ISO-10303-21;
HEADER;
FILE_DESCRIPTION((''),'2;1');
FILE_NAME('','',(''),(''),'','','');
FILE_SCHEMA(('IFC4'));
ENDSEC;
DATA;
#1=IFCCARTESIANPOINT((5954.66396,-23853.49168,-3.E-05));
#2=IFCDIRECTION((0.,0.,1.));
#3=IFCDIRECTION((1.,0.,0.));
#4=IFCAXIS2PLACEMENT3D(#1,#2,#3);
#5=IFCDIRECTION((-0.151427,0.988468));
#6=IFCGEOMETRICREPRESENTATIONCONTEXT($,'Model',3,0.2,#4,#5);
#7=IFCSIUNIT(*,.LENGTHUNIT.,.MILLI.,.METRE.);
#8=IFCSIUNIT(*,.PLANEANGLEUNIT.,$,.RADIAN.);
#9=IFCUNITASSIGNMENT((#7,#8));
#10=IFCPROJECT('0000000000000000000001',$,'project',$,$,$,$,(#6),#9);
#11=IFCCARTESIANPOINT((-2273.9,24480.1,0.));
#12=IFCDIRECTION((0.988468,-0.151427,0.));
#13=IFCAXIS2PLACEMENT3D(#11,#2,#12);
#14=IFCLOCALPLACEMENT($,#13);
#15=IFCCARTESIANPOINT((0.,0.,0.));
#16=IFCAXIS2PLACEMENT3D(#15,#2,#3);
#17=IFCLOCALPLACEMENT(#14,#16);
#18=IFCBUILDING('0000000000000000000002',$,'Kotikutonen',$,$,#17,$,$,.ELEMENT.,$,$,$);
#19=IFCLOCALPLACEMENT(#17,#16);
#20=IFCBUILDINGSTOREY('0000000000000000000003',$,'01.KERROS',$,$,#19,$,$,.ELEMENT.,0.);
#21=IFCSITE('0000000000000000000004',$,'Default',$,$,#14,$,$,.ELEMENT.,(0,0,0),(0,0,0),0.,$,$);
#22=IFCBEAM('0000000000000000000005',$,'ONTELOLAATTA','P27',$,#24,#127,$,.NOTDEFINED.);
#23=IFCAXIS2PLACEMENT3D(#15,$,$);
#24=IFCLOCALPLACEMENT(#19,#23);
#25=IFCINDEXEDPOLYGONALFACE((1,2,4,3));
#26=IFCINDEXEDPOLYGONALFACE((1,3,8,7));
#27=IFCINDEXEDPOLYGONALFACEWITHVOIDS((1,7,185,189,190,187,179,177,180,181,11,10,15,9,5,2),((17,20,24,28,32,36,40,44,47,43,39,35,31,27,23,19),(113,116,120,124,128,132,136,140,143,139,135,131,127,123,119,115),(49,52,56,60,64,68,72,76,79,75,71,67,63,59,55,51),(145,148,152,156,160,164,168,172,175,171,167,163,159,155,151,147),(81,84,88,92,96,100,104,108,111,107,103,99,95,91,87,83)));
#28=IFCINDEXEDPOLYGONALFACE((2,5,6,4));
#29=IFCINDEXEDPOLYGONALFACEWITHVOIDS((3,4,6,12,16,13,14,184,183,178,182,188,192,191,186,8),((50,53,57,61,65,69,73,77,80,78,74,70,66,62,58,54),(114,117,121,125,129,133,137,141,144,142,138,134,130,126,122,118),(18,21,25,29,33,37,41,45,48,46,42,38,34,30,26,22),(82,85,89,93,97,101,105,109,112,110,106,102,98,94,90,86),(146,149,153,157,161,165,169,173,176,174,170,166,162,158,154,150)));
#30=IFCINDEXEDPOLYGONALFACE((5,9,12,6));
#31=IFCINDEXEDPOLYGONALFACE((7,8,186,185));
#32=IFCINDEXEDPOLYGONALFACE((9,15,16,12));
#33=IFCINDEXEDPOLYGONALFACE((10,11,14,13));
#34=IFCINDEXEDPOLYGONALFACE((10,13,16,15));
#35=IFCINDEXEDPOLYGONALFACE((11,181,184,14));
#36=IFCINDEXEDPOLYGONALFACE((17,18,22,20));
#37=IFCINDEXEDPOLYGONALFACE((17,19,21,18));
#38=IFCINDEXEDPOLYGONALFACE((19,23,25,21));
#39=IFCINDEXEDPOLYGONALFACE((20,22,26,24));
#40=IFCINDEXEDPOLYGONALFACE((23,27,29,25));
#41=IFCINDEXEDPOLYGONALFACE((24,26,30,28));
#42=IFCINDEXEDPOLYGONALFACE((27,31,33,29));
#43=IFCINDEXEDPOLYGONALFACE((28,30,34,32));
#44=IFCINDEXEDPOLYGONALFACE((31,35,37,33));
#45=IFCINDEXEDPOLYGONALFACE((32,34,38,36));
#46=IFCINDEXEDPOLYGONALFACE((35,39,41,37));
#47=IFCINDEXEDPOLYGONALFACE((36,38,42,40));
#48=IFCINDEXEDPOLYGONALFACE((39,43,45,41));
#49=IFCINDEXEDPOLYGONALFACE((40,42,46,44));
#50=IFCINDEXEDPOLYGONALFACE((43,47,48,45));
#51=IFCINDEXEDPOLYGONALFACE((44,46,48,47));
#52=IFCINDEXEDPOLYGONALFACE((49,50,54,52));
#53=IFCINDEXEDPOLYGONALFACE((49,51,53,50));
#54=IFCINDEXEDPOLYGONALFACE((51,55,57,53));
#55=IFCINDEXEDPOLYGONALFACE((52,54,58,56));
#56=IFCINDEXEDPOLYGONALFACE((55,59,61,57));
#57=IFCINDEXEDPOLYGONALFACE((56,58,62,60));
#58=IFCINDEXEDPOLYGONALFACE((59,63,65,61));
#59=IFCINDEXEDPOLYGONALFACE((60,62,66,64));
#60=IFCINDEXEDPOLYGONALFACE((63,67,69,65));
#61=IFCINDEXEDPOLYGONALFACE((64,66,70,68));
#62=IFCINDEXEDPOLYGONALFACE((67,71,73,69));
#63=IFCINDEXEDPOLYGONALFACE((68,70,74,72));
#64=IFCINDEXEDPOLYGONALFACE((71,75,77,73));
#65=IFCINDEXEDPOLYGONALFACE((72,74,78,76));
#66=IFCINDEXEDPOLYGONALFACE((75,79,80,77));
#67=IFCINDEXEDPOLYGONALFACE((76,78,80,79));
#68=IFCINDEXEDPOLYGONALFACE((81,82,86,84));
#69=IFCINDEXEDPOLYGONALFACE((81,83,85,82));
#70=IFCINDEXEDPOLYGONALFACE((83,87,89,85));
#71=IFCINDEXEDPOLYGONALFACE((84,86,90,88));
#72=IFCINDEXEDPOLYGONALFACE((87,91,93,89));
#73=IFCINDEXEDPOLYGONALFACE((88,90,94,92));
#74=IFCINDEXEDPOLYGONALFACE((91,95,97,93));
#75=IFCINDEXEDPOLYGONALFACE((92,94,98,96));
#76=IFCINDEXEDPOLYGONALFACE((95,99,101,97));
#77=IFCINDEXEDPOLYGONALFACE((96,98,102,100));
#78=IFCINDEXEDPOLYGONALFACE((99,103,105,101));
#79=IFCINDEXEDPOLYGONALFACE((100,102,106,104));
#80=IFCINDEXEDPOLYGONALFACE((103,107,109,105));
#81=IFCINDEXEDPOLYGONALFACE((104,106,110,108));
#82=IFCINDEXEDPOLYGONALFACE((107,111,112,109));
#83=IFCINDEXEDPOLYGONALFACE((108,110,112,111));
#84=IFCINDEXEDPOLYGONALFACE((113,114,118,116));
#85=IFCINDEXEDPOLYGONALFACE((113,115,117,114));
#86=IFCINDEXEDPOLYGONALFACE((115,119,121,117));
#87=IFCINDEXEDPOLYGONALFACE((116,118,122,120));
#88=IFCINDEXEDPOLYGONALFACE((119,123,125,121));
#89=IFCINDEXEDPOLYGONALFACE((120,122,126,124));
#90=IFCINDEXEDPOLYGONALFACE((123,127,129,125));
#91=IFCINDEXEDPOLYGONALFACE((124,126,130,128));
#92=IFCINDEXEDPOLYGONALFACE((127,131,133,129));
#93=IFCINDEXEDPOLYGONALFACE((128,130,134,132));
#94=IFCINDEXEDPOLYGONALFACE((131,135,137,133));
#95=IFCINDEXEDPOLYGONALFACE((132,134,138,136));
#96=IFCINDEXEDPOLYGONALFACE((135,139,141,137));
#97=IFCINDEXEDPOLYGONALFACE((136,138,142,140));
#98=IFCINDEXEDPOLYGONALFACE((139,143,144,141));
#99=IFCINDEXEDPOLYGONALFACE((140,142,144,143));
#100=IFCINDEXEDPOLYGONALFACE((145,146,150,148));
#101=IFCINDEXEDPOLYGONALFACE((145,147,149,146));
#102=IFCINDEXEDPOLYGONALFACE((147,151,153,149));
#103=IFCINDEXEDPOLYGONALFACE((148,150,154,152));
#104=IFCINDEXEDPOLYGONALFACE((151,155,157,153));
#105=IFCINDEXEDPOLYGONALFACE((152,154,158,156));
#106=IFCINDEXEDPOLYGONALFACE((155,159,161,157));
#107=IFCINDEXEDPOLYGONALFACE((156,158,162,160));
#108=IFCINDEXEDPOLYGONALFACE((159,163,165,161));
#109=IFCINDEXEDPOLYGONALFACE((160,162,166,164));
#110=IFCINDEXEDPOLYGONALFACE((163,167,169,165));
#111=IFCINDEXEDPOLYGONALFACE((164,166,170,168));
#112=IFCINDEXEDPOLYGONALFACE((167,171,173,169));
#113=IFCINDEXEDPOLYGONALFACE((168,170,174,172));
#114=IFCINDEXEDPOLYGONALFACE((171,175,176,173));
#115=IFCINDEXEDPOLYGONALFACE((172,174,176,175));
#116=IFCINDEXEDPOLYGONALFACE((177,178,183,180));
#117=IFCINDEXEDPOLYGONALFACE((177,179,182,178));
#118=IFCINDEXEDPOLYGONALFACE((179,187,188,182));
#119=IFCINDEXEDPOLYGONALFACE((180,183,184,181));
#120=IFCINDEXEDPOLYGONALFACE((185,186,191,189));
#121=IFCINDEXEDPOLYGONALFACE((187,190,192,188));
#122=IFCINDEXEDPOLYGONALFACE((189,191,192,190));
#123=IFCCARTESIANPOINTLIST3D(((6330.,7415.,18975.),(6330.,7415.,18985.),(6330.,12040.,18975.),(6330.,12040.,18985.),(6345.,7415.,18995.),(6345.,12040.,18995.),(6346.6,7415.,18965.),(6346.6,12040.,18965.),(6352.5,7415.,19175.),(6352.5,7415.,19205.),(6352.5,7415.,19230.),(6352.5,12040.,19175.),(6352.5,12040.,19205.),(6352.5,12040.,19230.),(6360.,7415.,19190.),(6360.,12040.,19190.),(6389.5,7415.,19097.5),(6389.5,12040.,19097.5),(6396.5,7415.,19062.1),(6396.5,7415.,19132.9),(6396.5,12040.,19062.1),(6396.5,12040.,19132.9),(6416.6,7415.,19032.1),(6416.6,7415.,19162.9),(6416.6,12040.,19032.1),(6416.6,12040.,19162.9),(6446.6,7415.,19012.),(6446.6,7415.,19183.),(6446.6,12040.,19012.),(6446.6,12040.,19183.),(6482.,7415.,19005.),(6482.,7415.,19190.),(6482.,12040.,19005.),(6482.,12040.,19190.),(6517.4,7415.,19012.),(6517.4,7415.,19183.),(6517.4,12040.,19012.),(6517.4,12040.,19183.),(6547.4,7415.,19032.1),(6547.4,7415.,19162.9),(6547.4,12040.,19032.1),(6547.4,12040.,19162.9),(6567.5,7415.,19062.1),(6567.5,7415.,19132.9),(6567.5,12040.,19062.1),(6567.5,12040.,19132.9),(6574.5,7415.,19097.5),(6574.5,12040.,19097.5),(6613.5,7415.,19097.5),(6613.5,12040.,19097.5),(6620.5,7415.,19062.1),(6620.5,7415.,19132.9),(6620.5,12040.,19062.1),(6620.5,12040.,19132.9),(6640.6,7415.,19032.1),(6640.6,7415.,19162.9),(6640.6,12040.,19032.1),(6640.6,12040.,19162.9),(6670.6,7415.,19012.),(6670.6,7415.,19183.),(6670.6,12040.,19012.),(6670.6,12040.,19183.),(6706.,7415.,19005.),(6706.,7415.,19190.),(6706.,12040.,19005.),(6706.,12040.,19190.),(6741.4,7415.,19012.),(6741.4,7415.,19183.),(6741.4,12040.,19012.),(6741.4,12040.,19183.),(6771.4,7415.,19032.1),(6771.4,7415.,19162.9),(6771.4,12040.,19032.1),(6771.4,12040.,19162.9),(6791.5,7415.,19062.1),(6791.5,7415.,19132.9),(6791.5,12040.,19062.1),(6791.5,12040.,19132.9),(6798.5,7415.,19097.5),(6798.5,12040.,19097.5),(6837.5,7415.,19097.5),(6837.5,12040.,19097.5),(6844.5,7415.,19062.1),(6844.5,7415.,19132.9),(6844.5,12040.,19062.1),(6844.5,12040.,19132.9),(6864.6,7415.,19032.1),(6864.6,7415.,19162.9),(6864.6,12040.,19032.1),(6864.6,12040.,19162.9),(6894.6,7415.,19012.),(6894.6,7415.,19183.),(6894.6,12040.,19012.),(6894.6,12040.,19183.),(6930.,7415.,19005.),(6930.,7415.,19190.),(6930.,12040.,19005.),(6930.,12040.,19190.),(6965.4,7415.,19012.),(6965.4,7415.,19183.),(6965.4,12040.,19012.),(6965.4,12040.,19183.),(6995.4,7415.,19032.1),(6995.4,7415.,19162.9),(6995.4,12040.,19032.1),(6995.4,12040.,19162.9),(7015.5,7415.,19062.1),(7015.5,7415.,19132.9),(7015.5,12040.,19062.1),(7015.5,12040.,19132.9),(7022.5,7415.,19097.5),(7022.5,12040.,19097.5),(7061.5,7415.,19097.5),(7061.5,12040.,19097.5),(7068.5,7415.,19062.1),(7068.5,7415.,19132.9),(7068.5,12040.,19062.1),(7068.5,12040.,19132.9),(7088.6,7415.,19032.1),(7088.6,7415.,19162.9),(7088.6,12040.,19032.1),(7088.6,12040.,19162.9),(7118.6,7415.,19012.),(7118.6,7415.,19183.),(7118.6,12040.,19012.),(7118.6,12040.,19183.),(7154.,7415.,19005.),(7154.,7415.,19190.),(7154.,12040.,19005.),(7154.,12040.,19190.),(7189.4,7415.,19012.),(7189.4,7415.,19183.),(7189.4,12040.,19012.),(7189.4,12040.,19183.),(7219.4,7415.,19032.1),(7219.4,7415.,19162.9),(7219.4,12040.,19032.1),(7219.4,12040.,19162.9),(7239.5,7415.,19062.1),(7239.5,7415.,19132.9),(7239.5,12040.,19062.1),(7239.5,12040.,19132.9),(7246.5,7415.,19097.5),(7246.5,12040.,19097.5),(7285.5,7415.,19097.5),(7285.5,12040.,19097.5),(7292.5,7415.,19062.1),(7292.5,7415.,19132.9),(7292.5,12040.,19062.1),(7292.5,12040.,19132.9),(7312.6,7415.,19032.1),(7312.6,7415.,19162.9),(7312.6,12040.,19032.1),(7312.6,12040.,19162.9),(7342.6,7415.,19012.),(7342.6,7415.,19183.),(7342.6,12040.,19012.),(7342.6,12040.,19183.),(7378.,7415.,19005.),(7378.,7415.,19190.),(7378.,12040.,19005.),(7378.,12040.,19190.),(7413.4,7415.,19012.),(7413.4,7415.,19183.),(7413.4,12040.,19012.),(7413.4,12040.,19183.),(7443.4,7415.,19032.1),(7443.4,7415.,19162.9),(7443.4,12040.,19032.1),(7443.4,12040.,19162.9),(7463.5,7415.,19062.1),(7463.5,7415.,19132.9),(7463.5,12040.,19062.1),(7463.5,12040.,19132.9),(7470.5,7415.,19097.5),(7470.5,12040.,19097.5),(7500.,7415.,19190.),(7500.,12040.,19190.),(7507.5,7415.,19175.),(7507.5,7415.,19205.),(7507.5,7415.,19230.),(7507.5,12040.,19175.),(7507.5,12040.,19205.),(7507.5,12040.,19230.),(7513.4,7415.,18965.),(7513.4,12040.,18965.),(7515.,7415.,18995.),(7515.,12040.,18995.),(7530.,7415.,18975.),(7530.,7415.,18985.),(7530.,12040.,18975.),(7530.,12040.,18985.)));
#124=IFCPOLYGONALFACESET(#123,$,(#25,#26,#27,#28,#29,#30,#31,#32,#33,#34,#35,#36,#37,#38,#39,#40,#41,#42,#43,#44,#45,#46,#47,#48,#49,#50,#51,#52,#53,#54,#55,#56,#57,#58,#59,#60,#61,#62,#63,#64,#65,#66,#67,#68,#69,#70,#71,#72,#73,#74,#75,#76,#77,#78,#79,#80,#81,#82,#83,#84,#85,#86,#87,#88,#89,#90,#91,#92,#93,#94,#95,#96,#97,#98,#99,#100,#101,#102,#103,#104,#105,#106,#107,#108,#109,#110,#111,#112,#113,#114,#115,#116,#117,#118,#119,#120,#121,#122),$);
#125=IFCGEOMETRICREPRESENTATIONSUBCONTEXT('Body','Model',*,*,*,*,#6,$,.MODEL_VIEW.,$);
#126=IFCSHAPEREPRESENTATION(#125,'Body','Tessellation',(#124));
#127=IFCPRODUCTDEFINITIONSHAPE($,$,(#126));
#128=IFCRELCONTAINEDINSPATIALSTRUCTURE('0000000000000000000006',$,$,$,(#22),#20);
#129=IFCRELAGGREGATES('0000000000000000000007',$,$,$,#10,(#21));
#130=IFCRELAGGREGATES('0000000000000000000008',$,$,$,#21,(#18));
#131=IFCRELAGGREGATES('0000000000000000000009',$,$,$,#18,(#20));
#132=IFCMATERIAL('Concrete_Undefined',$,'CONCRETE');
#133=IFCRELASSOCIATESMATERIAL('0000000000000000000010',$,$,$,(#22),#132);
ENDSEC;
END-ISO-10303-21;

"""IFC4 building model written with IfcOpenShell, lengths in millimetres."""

from ifc_helpers import new_model, si_unit, direction, frame, origin_with_axes, place, context, subcontext, project, spatial, line, indexed_curve, outline, extrude, material, element, save


model = new_model("IFC4")

# Units and contexts
model_context = context("Model", 3, precision=0.2, world=frame((5954.66396, -23853.49168, -3e-05), z_axis=(0.0, 0.0, 1.0), x_axis=(1.0, 0.0, 0.0)), true_north=direction((-0.151427, 0.988468)))
body_context = subcontext(model_context, "Body", "Model", "MODEL_VIEW")
ifc_project = project(units=[si_unit("LENGTHUNIT", "METRE", prefix="MILLI"), si_unit("PLANEANGLEUNIT", "RADIAN")], contexts=[model_context])

# Site, building, storey
site_placement = place(None, frame((-2273.9, 24480.1, 0.0), z_axis=(0.0, 0.0, 1.0), x_axis=(0.988468, -0.151427, 0.0)))
site = spatial("IfcSite", under=ifc_project, at=site_placement, Name="Default", CompositionType="ELEMENT", RefLatitude=(0, 0, 0), RefLongitude=(0, 0, 0), RefElevation=0.0)
building_placement = place(site_placement, origin_with_axes())
building = spatial("IfcBuilding", under=site, at=building_placement, Name="Kotikutonen", CompositionType="ELEMENT")
storey_placement = place(building_placement, origin_with_axes())
storey = spatial("IfcBuildingStorey", under=building, at=storey_placement, Name="01.KERROS", CompositionType="ELEMENT", Elevation=0.0)

# Shared definitions
ifc_material_1 = material(Name="Concrete_Undefined", Category="CONCRETE")

# Beam
beam_1_placement = place(storey_placement, frame((6930.0, 12040.0, 19097.5), z_axis=(-1.0, 0.0, 0.0), x_axis=(0.0, -1.0, 0.0)))
element("IfcBeam", 1, at=beam_1_placement, inside=storey, material=ifc_material_1, Name="ONTELOLAATTA", Description="P27", PredefinedType="NOTDEFINED", context=body_context, shape_type="SolidModel", body=[
    extrude(outline(indexed_curve([(-600.0, -122.5), (-583.4, -132.5), (583.4, -132.5), (600.0, -122.5), (600.0, -112.5), (585.0, -102.5), (577.5, 77.5), (570.0, 92.5), (577.5, 107.5), (577.5, 132.5), (-577.5, 132.5), (-577.5, 107.5), (-570.0, 92.5), (-577.5, 77.5), (-585.0, -102.5), (-600.0, -112.5)], segments=[line(1, 2, 3, 4, 5, 6, 7, 8, 9, 10, 11, 12, 13, 14, 15, 16, 1)]), holes=[indexed_curve([(-448.0, -92.5), (-483.4, -85.5), (-513.4, -65.4), (-533.5, -35.4), (-540.5, 0.0), (-533.5, 35.4), (-513.4, 65.4), (-483.4, 85.5), (-448.0, 92.5), (-412.6, 85.5), (-382.6, 65.4), (-362.5, 35.4), (-355.5, 0.0), (-362.5, -35.4), (-382.6, -65.4), (-412.6, -85.5)], segments=[line(1, 2, 3, 4, 5, 6, 7, 8, 9, 10, 11, 12, 13, 14, 15, 16, 1)]), indexed_curve([(-224.0, -92.5), (-259.4, -85.5), (-289.4, -65.4), (-309.5, -35.4), (-316.5, 0.0), (-309.5, 35.4), (-289.4, 65.4), (-259.4, 85.5), (-224.0, 92.5), (-188.6, 85.5), (-158.6, 65.4), (-138.5, 35.4), (-131.5, 0.0), (-138.5, -35.4), (-158.6, -65.4), (-188.6, -85.5)], segments=[line(1, 2, 3, 4, 5, 6, 7, 8, 9, 10, 11, 12, 13, 14, 15, 16, 1)]), indexed_curve([(0.0, -92.5), (-35.4, -85.5), (-65.4, -65.4), (-85.5, -35.4), (-92.5, 0.0), (-85.5, 35.4), (-65.4, 65.4), (-35.4, 85.5), (0.0, 92.5), (35.4, 85.5), (65.4, 65.4), (85.5, 35.4), (92.5, 0.0), (85.5, -35.4), (65.4, -65.4), (35.4, -85.5)], segments=[line(1, 2, 3, 4, 5, 6, 7, 8, 9, 10, 11, 12, 13, 14, 15, 16, 1)]), indexed_curve([(224.0, -92.5), (188.6, -85.5), (158.6, -65.4), (138.5, -35.4), (131.5, 0.0), (138.5, 35.4), (158.6, 65.4), (188.6, 85.5), (224.0, 92.5), (259.4, 85.5), (289.4, 65.4), (309.5, 35.4), (316.5, 0.0), (309.5, -35.4), (289.4, -65.4), (259.4, -85.5)], segments=[line(1, 2, 3, 4, 5, 6, 7, 8, 9, 10, 11, 12, 13, 14, 15, 16, 1)]), indexed_curve([(448.0, -92.5), (412.6, -85.5), (382.6, -65.4), (362.5, -35.4), (355.5, 0.0), (362.5, 35.4), (382.6, 65.4), (412.6, 85.5), (448.0, 92.5), (483.4, 85.5), (513.4, 65.4), (533.5, 35.4), (540.5, 0.0), (533.5, -35.4), (513.4, -65.4), (483.4, -85.5)], segments=[line(1, 2, 3, 4, 5, 6, 7, 8, 9, 10, 11, 12, 13, 14, 15, 16, 1)])]), frame((0.0, 0.0, 0.0), z_axis=(-1.0, 0.0, 0.0), x_axis=(0.0, 0.0, 1.0)), (0.0, 0.0, -1.0), 4625.0),
])

save(model, "model.ifc")
